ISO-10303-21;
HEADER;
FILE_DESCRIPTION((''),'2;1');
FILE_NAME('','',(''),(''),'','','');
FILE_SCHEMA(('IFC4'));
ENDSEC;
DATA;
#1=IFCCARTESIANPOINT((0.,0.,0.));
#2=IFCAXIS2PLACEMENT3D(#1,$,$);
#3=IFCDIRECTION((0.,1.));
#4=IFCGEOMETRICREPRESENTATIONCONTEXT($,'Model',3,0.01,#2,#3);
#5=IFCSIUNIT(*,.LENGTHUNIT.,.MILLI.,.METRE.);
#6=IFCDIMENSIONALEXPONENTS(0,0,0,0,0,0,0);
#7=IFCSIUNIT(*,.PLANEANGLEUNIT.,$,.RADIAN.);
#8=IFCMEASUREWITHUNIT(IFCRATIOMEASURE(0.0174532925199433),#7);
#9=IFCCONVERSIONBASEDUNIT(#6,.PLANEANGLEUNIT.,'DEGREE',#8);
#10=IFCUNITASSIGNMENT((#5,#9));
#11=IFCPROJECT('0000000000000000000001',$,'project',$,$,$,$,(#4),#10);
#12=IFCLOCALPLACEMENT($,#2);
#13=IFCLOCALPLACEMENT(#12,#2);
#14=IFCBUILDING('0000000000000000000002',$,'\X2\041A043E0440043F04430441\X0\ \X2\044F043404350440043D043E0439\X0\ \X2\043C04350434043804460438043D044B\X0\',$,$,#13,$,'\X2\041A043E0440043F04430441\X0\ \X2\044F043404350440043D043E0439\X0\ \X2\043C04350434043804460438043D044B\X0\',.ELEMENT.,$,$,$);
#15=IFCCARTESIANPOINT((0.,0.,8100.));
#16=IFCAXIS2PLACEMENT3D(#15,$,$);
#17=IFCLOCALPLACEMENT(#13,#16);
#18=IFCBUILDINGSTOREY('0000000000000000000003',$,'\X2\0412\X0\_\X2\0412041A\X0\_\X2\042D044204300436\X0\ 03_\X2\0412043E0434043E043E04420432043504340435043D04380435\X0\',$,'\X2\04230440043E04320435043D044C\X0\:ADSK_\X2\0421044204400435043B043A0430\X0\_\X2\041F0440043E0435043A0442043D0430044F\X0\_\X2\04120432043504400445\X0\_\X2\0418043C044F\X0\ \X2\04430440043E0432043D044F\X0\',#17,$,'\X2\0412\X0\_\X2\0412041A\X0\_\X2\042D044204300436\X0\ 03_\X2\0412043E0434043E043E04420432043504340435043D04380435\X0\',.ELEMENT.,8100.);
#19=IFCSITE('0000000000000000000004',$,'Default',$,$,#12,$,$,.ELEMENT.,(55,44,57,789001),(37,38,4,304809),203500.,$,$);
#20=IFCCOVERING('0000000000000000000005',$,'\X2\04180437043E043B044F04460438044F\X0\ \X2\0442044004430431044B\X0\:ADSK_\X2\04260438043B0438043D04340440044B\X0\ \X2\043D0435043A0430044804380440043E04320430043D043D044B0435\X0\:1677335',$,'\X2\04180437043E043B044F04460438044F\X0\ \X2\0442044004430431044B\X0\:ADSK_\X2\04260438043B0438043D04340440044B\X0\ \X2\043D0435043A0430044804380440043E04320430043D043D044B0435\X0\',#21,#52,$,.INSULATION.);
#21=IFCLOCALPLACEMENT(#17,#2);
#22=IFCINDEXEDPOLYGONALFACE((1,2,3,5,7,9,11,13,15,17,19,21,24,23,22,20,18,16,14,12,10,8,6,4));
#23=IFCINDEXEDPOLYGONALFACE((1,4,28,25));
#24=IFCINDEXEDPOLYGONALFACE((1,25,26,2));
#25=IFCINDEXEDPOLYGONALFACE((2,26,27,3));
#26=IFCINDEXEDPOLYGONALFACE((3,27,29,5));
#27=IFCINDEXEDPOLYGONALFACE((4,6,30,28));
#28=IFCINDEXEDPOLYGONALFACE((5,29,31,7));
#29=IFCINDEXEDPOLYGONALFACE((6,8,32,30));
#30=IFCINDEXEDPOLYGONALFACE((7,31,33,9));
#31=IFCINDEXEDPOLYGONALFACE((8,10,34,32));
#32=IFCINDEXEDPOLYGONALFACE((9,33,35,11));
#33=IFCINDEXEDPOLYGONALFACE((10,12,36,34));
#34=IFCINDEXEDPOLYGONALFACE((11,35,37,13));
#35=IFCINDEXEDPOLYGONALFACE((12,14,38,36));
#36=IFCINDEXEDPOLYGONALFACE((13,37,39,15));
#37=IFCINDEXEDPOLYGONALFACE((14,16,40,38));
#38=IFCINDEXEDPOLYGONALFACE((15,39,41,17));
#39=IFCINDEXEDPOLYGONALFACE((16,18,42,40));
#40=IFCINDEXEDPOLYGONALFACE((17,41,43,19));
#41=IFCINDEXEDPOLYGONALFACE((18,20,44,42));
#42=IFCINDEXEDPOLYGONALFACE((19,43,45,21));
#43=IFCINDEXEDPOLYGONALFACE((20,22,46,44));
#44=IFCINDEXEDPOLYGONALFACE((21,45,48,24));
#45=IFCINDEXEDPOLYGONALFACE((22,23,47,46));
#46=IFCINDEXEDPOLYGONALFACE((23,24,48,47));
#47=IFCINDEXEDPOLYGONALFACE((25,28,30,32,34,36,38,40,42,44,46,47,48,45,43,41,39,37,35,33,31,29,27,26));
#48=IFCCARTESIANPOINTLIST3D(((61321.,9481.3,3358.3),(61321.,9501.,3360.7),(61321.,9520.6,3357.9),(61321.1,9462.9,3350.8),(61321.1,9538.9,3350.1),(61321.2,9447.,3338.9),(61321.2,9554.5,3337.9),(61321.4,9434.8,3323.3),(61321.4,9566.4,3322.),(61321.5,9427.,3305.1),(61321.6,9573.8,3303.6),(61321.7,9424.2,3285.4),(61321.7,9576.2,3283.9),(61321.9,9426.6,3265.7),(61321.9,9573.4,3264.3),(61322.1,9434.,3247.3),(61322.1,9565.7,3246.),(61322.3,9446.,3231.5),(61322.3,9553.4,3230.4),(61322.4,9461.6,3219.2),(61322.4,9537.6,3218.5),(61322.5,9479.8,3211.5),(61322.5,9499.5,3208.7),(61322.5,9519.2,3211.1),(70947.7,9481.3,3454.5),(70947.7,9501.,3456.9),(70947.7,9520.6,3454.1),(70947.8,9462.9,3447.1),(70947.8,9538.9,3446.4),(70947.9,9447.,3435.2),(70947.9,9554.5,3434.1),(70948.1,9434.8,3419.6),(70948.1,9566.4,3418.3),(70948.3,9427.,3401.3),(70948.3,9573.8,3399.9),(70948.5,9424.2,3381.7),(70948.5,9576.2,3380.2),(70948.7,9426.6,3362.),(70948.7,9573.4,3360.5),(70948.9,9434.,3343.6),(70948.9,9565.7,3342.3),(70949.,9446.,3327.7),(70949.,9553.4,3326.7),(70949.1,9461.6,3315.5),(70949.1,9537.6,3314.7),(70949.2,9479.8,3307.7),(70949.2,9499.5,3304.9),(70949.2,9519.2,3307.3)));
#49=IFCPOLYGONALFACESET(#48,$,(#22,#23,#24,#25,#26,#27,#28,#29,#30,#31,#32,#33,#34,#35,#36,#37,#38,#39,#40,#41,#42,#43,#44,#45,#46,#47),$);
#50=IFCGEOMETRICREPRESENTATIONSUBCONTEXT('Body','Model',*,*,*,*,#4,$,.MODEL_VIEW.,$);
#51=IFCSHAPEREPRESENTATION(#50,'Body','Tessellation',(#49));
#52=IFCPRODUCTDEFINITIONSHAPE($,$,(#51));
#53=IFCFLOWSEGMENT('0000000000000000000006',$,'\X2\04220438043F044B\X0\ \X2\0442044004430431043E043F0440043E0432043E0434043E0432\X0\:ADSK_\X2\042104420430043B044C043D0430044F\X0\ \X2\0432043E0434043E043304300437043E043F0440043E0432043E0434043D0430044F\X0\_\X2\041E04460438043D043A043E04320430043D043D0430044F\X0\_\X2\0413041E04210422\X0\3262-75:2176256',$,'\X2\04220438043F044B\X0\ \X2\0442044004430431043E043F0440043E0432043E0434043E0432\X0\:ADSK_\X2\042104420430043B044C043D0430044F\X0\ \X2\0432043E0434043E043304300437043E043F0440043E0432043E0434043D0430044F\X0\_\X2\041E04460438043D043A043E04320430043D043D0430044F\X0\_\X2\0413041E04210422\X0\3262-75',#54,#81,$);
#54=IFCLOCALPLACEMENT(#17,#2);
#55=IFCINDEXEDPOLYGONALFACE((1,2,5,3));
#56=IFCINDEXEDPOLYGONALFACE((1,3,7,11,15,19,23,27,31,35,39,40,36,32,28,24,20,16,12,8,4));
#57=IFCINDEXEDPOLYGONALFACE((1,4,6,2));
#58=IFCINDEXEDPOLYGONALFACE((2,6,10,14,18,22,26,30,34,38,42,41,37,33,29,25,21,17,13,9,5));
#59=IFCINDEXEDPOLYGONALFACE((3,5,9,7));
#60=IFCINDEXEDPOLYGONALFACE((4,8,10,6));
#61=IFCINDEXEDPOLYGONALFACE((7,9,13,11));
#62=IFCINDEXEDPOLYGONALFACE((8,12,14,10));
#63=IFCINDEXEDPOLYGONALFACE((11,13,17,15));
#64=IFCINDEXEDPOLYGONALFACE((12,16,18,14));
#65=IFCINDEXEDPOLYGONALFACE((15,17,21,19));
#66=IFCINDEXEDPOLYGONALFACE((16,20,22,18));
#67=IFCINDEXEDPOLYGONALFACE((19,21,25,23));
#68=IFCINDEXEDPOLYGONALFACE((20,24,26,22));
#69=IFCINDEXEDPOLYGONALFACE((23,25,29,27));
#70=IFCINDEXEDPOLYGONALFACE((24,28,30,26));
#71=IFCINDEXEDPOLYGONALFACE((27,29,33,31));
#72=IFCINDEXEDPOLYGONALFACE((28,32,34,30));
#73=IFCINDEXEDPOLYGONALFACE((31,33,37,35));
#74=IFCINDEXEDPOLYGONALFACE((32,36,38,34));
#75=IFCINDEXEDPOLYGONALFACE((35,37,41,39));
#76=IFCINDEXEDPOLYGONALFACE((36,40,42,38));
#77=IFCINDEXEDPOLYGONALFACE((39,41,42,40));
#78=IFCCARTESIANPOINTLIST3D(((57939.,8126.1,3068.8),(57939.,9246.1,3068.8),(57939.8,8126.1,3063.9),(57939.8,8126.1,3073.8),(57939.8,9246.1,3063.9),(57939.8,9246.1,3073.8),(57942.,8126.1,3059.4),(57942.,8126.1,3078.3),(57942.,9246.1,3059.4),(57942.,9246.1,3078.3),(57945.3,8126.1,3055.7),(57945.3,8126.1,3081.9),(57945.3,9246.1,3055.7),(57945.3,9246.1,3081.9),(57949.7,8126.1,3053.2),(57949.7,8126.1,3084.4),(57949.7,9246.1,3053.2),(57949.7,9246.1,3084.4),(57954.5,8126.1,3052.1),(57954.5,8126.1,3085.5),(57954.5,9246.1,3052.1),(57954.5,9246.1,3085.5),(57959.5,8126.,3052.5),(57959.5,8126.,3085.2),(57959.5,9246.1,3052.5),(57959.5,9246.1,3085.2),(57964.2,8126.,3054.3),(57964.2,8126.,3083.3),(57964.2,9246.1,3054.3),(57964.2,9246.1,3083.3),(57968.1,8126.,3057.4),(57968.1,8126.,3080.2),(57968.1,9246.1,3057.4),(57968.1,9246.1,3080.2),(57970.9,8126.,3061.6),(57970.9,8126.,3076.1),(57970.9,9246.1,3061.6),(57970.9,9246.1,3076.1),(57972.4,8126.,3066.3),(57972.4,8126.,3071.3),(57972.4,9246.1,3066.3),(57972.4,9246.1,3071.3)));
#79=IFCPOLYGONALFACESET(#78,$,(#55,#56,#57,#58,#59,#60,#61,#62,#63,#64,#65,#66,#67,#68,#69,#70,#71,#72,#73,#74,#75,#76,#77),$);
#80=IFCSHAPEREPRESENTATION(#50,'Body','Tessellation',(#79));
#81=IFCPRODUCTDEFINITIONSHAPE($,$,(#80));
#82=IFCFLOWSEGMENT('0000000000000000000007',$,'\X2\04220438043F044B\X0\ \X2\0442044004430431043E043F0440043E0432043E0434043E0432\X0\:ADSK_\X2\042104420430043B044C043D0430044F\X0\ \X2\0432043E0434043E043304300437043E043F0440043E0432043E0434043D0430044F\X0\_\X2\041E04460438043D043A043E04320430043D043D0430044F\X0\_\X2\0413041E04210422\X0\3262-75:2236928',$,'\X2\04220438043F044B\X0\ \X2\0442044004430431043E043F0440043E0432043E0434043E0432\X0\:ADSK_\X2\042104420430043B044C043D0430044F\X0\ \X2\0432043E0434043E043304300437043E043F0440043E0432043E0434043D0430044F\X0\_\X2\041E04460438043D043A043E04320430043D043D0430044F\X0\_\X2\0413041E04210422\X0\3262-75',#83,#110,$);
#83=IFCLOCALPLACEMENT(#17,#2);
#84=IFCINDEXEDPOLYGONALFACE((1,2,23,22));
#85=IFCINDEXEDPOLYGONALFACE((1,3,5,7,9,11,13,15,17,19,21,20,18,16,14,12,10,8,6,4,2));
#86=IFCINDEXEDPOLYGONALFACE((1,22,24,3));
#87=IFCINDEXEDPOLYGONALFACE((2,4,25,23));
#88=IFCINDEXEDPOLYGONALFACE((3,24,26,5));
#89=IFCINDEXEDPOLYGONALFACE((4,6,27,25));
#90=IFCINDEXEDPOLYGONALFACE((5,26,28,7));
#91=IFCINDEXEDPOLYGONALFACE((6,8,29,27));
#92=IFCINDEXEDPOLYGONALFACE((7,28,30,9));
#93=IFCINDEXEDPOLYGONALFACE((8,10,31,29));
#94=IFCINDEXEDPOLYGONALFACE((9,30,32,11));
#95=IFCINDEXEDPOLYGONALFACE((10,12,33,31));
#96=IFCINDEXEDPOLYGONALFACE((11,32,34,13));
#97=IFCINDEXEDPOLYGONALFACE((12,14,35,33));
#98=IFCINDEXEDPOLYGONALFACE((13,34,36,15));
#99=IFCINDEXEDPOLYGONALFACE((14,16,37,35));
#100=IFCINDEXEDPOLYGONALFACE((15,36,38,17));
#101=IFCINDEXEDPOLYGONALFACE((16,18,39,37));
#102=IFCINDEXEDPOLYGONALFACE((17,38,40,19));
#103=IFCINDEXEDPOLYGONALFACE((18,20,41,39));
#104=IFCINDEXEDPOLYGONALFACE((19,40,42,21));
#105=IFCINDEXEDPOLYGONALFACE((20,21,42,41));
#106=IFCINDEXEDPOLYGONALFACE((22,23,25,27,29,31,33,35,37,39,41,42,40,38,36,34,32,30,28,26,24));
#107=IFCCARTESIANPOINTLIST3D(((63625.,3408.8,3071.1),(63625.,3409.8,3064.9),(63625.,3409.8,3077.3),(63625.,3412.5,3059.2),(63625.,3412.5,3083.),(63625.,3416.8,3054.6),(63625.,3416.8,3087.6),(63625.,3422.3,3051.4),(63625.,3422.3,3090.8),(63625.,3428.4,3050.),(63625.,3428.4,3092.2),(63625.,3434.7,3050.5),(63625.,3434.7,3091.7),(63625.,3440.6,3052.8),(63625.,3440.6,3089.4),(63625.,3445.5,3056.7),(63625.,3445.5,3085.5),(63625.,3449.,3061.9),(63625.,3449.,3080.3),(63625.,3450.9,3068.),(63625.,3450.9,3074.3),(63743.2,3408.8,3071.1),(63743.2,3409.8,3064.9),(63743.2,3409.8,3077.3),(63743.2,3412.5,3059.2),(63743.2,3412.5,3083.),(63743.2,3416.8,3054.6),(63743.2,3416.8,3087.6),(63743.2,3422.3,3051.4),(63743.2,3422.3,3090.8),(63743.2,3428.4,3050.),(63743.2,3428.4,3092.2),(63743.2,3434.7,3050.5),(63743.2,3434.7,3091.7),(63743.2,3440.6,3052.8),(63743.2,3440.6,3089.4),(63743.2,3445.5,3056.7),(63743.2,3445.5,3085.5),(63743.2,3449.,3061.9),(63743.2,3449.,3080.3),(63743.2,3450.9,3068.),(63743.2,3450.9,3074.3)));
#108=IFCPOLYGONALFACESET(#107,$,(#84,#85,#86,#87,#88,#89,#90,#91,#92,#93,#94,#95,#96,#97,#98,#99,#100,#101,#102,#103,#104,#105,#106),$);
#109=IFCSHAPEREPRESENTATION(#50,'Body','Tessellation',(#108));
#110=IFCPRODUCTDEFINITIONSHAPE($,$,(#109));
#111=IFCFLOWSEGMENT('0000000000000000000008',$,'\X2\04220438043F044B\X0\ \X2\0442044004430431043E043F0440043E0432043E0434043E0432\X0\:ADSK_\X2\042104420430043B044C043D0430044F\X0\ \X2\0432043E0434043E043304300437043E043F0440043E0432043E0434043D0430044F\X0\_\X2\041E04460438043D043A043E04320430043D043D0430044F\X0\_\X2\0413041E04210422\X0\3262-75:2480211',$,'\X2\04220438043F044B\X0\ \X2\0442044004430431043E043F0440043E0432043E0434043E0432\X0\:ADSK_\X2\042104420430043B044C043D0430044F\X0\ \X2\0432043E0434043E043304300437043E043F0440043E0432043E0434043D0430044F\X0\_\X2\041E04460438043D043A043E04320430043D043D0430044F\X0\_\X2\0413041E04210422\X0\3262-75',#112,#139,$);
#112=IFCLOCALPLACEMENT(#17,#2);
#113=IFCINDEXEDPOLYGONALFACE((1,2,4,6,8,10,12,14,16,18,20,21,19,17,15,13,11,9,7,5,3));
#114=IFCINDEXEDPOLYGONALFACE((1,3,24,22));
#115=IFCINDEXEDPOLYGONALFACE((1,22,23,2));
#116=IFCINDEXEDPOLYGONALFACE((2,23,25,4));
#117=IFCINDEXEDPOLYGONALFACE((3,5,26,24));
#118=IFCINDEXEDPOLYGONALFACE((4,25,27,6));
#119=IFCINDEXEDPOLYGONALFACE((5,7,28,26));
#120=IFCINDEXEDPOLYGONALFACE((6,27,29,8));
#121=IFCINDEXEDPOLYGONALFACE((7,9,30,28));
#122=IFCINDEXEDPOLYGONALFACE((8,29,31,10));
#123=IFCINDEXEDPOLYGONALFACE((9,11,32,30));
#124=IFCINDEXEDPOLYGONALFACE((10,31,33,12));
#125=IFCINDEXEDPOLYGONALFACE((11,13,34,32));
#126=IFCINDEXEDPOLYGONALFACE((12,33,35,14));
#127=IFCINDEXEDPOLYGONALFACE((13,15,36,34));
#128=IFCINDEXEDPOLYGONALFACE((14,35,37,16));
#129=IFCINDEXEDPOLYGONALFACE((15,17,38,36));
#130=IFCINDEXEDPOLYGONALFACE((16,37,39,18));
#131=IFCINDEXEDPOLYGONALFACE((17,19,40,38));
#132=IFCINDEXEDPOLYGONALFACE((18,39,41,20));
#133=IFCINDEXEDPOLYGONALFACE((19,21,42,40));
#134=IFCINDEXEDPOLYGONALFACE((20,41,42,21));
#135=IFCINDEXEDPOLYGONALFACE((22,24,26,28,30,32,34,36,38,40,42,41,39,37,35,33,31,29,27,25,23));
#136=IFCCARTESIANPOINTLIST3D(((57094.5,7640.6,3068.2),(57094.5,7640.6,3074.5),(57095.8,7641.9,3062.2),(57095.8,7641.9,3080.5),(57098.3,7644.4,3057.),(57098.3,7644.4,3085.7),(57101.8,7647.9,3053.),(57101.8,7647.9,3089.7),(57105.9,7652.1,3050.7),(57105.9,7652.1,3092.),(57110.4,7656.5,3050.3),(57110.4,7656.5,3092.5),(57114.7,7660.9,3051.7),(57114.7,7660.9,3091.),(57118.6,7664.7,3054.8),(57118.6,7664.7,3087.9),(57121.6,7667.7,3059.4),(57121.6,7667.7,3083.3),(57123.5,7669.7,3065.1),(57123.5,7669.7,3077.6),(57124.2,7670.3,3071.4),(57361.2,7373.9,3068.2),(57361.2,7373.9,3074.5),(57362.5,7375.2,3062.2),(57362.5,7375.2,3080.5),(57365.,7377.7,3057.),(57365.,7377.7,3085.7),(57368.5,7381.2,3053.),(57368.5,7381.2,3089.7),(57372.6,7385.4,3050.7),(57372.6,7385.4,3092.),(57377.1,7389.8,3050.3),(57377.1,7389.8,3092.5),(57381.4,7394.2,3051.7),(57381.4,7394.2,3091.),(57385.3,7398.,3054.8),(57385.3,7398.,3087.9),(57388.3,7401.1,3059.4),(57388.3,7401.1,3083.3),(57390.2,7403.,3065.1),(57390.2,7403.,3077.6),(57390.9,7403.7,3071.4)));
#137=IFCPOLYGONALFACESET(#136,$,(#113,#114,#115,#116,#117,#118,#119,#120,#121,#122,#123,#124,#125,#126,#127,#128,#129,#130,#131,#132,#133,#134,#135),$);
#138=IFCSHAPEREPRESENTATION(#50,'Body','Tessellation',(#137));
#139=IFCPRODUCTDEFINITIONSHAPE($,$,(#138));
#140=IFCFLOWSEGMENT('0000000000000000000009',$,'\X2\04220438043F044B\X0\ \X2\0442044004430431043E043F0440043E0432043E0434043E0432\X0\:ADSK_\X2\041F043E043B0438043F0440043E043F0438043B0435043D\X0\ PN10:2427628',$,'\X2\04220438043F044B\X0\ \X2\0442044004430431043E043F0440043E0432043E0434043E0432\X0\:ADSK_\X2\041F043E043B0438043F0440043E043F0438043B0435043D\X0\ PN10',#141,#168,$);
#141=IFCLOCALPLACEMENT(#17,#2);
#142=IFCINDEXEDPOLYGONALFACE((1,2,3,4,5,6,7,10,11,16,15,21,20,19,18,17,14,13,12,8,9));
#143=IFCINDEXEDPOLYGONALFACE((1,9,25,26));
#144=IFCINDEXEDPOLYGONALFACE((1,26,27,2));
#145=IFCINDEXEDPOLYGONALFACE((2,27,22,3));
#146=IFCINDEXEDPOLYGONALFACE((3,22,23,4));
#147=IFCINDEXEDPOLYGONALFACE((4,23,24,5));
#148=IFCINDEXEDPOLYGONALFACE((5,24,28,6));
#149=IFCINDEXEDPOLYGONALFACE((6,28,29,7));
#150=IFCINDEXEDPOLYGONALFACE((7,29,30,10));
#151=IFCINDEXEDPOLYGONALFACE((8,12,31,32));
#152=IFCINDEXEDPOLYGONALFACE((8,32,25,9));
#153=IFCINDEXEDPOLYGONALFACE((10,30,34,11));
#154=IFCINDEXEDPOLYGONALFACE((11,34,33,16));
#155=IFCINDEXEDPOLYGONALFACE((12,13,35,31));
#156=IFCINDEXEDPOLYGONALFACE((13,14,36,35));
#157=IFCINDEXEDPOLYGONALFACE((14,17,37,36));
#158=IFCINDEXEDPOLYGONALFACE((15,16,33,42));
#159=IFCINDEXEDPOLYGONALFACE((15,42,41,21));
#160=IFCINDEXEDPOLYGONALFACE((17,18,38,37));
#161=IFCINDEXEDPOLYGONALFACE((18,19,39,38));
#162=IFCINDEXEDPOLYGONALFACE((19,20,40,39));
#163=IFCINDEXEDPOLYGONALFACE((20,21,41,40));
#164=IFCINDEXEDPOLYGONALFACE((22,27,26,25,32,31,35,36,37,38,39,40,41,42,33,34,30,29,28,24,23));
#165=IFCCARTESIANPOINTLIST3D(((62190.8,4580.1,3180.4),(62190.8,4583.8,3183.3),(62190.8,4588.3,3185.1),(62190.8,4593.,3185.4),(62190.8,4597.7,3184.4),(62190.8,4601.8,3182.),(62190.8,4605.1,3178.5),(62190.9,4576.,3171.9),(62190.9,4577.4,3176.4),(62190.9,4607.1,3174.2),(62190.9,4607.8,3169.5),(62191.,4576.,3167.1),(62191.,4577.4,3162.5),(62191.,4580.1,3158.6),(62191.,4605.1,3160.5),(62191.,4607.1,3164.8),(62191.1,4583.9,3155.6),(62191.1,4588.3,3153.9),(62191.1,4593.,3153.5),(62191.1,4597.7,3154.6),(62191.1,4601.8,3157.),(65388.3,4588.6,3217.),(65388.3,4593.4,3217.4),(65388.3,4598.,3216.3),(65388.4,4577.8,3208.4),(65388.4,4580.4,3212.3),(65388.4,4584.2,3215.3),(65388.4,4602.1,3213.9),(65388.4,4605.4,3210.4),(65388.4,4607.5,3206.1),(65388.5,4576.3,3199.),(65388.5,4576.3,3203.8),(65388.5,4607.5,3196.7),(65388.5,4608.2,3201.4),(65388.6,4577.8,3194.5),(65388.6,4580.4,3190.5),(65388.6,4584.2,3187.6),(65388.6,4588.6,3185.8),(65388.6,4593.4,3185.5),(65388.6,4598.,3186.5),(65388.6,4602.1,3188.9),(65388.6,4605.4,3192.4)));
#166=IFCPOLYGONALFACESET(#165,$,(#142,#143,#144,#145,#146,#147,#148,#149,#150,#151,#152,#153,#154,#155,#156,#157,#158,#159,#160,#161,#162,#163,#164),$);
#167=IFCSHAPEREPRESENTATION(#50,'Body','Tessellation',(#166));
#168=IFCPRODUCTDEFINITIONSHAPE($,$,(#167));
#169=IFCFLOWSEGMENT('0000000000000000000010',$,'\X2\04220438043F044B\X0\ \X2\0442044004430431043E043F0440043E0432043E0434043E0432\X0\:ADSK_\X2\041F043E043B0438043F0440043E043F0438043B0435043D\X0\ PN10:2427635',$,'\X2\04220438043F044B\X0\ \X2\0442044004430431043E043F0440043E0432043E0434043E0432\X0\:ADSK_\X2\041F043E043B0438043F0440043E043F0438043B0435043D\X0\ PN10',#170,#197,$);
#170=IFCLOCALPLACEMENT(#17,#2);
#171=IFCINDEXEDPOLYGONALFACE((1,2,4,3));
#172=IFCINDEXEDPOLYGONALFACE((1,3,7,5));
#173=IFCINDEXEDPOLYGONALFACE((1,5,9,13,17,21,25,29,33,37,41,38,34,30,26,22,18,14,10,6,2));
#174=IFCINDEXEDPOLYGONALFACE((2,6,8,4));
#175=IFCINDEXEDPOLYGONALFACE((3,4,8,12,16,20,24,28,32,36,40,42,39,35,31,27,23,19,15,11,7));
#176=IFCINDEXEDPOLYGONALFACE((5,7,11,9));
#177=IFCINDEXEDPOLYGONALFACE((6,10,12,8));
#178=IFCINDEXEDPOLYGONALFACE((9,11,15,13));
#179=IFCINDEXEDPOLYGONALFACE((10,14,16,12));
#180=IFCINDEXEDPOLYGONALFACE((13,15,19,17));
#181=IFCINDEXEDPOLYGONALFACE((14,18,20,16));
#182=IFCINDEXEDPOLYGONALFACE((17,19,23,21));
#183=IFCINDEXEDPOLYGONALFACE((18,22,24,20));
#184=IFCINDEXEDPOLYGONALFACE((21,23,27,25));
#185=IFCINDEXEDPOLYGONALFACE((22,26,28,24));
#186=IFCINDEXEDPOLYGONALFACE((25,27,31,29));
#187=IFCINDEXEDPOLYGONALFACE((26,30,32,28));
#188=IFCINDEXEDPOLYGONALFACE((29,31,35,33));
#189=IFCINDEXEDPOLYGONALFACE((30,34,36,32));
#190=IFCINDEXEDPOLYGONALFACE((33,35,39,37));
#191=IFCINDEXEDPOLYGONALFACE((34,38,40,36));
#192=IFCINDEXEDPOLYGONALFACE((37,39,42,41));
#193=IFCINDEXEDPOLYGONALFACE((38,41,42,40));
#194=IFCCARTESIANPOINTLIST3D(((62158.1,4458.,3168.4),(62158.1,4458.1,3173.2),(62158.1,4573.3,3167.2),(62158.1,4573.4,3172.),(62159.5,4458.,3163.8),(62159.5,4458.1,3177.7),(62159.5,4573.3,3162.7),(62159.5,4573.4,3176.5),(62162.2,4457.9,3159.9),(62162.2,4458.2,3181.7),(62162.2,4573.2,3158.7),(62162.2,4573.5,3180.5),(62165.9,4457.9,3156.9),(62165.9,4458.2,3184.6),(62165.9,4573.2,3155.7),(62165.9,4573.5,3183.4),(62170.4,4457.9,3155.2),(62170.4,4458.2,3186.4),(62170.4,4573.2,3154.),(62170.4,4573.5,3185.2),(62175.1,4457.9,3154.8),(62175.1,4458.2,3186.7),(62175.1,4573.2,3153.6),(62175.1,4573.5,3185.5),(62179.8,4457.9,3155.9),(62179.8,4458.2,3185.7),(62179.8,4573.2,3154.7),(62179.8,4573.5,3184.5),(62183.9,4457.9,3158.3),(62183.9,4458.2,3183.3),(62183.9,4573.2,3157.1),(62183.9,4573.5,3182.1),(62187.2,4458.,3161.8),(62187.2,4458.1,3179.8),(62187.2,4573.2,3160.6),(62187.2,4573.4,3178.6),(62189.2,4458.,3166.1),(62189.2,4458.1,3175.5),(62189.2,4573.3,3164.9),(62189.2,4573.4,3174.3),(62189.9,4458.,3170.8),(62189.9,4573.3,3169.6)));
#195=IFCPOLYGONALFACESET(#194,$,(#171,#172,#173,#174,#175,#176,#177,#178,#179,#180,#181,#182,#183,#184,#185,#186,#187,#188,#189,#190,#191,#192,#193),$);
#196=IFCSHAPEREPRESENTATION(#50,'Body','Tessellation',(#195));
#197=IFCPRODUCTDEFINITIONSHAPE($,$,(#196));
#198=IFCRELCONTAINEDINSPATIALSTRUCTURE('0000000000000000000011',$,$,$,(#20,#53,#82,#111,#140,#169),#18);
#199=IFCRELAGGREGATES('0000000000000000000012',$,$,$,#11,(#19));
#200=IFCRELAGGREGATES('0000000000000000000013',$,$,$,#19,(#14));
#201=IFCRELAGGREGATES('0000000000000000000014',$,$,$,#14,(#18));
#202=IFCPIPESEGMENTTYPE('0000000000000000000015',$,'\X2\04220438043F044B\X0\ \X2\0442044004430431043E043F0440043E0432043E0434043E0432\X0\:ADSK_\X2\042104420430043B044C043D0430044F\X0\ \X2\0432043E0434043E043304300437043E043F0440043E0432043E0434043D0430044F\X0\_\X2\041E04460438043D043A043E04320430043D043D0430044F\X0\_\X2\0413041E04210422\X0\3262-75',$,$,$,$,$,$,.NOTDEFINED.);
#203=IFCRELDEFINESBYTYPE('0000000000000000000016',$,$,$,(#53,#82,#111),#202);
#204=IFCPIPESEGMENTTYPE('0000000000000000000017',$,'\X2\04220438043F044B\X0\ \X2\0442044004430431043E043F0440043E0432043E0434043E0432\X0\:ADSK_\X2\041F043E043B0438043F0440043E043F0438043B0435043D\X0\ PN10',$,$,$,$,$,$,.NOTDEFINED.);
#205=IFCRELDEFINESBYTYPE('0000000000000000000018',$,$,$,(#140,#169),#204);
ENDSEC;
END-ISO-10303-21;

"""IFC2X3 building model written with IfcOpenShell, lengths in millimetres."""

from ifc_helpers import new_model, entity, si_unit, converted_unit, direction, frame, origin, origin_2d_with_axis, place, context, subcontext, project, spatial, polyline, circle, outline, extrude, type_object, element, save


model = new_model("IFC2X3")

# Units and contexts
model_context = context("Model", 3, precision=0.01, world=origin(), true_north=direction((0.0, 1.0)))
body_context = subcontext(model_context, "Body", "Model", "MODEL_VIEW")
ifc_project = project(units=[si_unit("LENGTHUNIT", "METRE", prefix="MILLI"), converted_unit("PLANEANGLEUNIT", "DEGREE", entity("IfcRatioMeasure", 0.0174532925199433), si_unit("PLANEANGLEUNIT", "RADIAN"), dimensions=[0, 0, 0, 0, 0, 0, 0])], contexts=[model_context])

# Site, building, storey
site_placement = place(None, origin())
site = spatial("IfcSite", under=ifc_project, at=site_placement, Name="Default", CompositionType="ELEMENT", RefLatitude=(55, 44, 57, 789001), RefLongitude=(37, 38, 4, 304809), RefElevation=203500.0)
building_placement = place(site_placement, origin())
building = spatial("IfcBuilding", under=site, at=building_placement, Name="Корпус ядерной медицины", LongName="Корпус ядерной медицины", CompositionType="ELEMENT")
storey_placement = place(building_placement, frame((0.0, 0.0, 8100.0)))
storey = spatial("IfcBuildingStorey", under=building, at=storey_placement, Name="В_ВК_Этаж 03_Водоотведение", ObjectType="Уровень:ADSK_Стрелка_Проектная_Вверх_Имя уровня", LongName="В_ВК_Этаж 03_Водоотведение", CompositionType="ELEMENT", Elevation=8100.0)

# Covering
covering_placement = place(storey_placement, frame((61319.4, 9422.6, 3207.1)))
element("IfcCovering", 1, at=covering_placement, inside=storey, Name="Изоляция трубы:ADSK_Цилиндры некашированные:1677335", ObjectType="Изоляция трубы:ADSK_Цилиндры некашированные", PredefinedType="INSULATION", context=body_context, shape_type="SweptSolid", body=[
    extrude(outline(polyline([(-9.9, -75.3), (9.9, -75.3), (29.1, -70.2), (46.3, -60.3), (60.3, -46.3), (70.2, -29.1), (75.3, -9.9), (75.3, 9.9), (70.2, 29.1), (60.3, 46.3), (46.3, 60.3), (29.1, 70.2), (9.9, 75.3), (-9.9, 75.3), (-29.1, 70.2), (-46.3, 60.3), (-60.3, 46.3), (-70.2, 29.1), (-75.3, 9.9), (-75.3, -9.9), (-70.2, -29.1), (-60.3, -46.3), (-46.3, -60.3), (-29.1, -70.2), (-9.9, -75.3)])), frame((2.4, 77.6, 77.6), z_axis=(0.99995, 0.0, 0.01), x_axis=(0.001206, -0.9927, -0.1206)), (0.0, 0.0, 1.0), 9627.2),
])

# Flow segments
pipe_segment_type_1 = type_object("IfcPipeSegmentType", Name="Типы трубопроводов:ADSK_Стальная водогазопроводная_Оцинкованная_ГОСТ3262-75", PredefinedType="NOTDEFINED")
flow_segment_1_placement = place(storey_placement, frame((57937.4, 8126.1, 3050.5)))
element("IfcFlowSegment", 2, at=flow_segment_1_placement, inside=storey, type_object=pipe_segment_type_1, Name="Типы трубопроводов:ADSK_Стальная водогазопроводная_Оцинкованная_ГОСТ3262-75:2176256", ObjectType="Типы трубопроводов:ADSK_Стальная водогазопроводная_Оцинкованная_ГОСТ3262-75", context=body_context, shape_type="SweptSolid", body=[
    extrude(circle(Radius=16.8, at=origin_2d_with_axis()), frame((18.4, 0.0, 18.4), z_axis=(0.000001, 1.0, 0.0), x_axis=(-1.0, 0.000001, 0.0)), (0.0, 0.0, 1.0), 1120.0),
])
flow_segment_2_placement = place(storey_placement, frame((63625.0, 3407.2, 3048.4)))
element("IfcFlowSegment", 3, at=flow_segment_2_placement, inside=storey, type_object=pipe_segment_type_1, Name="Типы трубопроводов:ADSK_Стальная водогазопроводная_Оцинкованная_ГОСТ3262-75:2236928", ObjectType="Типы трубопроводов:ADSK_Стальная водогазопроводная_Оцинкованная_ГОСТ3262-75", context=body_context, shape_type="SweptSolid", body=[
    extrude(circle(Radius=21.1, at=origin_2d_with_axis()), frame((0.0, 22.8, 22.8), z_axis=(1.0, 0.000003, 0.0), x_axis=(0.000003, -1.0, 0.0)), (0.0, 0.0, 1.0), 118.2),
])
flow_segment_3_placement = place(storey_placement, frame((57092.7, 7372.1, 3048.6)))
element("IfcFlowSegment", 4, at=flow_segment_3_placement, inside=storey, type_object=pipe_segment_type_1, Name="Типы трубопроводов:ADSK_Стальная водогазопроводная_Оцинкованная_ГОСТ3262-75:2480211", ObjectType="Типы трубопроводов:ADSK_Стальная водогазопроводная_Оцинкованная_ГОСТ3262-75", context=body_context, shape_type="SweptSolid", body=[
    extrude(circle(Radius=21.1, at=origin_2d_with_axis()), frame((283.2, 16.6, 22.8), z_axis=(-0.707107, 0.707107, 0.0), x_axis=(0.707107, 0.707107, 0.0)), (0.0, 0.0, 1.0), 377.2),
])
pipe_segment_type_2 = type_object("IfcPipeSegmentType", Name="Типы трубопроводов:ADSK_Полипропилен PN10", PredefinedType="NOTDEFINED")
flow_segment_4_placement = place(storey_placement, frame((62189.2, 4574.2, 3151.9)))
element("IfcFlowSegment", 5, at=flow_segment_4_placement, inside=storey, type_object=pipe_segment_type_2, Name="Типы трубопроводов:ADSK_Полипропилен PN10:2427628", ObjectType="Типы трубопроводов:ADSK_Полипропилен PN10", context=body_context, shape_type="SweptSolid", body=[
    extrude(circle(Radius=16.0, at=origin_2d_with_axis()), frame((1.8, 17.6, 17.6), z_axis=(0.99995, 0.0001, 0.009991), x_axis=(-0.0001, 1.0, 0.0)), (0.0, 0.0, 1.0), 3197.7),
])
flow_segment_5_placement = place(storey_placement, frame((62156.3, 4456.3, 3152.0)))
element("IfcFlowSegment", 6, at=flow_segment_5_placement, inside=storey, type_object=pipe_segment_type_2, Name="Типы трубопроводов:ADSK_Полипропилен PN10:2427635", ObjectType="Типы трубопроводов:ADSK_Полипропилен PN10", context=body_context, shape_type="SweptSolid", body=[
    extrude(circle(Radius=16.0, at=origin_2d_with_axis()), frame((17.6, 1.8, 18.8), z_axis=(0.000002, 0.999948, -0.010216), x_axis=(1.0, -0.000002, 0.0)), (0.0, 0.0, 1.0), 115.3),
])

save(model, "model.ifc")
